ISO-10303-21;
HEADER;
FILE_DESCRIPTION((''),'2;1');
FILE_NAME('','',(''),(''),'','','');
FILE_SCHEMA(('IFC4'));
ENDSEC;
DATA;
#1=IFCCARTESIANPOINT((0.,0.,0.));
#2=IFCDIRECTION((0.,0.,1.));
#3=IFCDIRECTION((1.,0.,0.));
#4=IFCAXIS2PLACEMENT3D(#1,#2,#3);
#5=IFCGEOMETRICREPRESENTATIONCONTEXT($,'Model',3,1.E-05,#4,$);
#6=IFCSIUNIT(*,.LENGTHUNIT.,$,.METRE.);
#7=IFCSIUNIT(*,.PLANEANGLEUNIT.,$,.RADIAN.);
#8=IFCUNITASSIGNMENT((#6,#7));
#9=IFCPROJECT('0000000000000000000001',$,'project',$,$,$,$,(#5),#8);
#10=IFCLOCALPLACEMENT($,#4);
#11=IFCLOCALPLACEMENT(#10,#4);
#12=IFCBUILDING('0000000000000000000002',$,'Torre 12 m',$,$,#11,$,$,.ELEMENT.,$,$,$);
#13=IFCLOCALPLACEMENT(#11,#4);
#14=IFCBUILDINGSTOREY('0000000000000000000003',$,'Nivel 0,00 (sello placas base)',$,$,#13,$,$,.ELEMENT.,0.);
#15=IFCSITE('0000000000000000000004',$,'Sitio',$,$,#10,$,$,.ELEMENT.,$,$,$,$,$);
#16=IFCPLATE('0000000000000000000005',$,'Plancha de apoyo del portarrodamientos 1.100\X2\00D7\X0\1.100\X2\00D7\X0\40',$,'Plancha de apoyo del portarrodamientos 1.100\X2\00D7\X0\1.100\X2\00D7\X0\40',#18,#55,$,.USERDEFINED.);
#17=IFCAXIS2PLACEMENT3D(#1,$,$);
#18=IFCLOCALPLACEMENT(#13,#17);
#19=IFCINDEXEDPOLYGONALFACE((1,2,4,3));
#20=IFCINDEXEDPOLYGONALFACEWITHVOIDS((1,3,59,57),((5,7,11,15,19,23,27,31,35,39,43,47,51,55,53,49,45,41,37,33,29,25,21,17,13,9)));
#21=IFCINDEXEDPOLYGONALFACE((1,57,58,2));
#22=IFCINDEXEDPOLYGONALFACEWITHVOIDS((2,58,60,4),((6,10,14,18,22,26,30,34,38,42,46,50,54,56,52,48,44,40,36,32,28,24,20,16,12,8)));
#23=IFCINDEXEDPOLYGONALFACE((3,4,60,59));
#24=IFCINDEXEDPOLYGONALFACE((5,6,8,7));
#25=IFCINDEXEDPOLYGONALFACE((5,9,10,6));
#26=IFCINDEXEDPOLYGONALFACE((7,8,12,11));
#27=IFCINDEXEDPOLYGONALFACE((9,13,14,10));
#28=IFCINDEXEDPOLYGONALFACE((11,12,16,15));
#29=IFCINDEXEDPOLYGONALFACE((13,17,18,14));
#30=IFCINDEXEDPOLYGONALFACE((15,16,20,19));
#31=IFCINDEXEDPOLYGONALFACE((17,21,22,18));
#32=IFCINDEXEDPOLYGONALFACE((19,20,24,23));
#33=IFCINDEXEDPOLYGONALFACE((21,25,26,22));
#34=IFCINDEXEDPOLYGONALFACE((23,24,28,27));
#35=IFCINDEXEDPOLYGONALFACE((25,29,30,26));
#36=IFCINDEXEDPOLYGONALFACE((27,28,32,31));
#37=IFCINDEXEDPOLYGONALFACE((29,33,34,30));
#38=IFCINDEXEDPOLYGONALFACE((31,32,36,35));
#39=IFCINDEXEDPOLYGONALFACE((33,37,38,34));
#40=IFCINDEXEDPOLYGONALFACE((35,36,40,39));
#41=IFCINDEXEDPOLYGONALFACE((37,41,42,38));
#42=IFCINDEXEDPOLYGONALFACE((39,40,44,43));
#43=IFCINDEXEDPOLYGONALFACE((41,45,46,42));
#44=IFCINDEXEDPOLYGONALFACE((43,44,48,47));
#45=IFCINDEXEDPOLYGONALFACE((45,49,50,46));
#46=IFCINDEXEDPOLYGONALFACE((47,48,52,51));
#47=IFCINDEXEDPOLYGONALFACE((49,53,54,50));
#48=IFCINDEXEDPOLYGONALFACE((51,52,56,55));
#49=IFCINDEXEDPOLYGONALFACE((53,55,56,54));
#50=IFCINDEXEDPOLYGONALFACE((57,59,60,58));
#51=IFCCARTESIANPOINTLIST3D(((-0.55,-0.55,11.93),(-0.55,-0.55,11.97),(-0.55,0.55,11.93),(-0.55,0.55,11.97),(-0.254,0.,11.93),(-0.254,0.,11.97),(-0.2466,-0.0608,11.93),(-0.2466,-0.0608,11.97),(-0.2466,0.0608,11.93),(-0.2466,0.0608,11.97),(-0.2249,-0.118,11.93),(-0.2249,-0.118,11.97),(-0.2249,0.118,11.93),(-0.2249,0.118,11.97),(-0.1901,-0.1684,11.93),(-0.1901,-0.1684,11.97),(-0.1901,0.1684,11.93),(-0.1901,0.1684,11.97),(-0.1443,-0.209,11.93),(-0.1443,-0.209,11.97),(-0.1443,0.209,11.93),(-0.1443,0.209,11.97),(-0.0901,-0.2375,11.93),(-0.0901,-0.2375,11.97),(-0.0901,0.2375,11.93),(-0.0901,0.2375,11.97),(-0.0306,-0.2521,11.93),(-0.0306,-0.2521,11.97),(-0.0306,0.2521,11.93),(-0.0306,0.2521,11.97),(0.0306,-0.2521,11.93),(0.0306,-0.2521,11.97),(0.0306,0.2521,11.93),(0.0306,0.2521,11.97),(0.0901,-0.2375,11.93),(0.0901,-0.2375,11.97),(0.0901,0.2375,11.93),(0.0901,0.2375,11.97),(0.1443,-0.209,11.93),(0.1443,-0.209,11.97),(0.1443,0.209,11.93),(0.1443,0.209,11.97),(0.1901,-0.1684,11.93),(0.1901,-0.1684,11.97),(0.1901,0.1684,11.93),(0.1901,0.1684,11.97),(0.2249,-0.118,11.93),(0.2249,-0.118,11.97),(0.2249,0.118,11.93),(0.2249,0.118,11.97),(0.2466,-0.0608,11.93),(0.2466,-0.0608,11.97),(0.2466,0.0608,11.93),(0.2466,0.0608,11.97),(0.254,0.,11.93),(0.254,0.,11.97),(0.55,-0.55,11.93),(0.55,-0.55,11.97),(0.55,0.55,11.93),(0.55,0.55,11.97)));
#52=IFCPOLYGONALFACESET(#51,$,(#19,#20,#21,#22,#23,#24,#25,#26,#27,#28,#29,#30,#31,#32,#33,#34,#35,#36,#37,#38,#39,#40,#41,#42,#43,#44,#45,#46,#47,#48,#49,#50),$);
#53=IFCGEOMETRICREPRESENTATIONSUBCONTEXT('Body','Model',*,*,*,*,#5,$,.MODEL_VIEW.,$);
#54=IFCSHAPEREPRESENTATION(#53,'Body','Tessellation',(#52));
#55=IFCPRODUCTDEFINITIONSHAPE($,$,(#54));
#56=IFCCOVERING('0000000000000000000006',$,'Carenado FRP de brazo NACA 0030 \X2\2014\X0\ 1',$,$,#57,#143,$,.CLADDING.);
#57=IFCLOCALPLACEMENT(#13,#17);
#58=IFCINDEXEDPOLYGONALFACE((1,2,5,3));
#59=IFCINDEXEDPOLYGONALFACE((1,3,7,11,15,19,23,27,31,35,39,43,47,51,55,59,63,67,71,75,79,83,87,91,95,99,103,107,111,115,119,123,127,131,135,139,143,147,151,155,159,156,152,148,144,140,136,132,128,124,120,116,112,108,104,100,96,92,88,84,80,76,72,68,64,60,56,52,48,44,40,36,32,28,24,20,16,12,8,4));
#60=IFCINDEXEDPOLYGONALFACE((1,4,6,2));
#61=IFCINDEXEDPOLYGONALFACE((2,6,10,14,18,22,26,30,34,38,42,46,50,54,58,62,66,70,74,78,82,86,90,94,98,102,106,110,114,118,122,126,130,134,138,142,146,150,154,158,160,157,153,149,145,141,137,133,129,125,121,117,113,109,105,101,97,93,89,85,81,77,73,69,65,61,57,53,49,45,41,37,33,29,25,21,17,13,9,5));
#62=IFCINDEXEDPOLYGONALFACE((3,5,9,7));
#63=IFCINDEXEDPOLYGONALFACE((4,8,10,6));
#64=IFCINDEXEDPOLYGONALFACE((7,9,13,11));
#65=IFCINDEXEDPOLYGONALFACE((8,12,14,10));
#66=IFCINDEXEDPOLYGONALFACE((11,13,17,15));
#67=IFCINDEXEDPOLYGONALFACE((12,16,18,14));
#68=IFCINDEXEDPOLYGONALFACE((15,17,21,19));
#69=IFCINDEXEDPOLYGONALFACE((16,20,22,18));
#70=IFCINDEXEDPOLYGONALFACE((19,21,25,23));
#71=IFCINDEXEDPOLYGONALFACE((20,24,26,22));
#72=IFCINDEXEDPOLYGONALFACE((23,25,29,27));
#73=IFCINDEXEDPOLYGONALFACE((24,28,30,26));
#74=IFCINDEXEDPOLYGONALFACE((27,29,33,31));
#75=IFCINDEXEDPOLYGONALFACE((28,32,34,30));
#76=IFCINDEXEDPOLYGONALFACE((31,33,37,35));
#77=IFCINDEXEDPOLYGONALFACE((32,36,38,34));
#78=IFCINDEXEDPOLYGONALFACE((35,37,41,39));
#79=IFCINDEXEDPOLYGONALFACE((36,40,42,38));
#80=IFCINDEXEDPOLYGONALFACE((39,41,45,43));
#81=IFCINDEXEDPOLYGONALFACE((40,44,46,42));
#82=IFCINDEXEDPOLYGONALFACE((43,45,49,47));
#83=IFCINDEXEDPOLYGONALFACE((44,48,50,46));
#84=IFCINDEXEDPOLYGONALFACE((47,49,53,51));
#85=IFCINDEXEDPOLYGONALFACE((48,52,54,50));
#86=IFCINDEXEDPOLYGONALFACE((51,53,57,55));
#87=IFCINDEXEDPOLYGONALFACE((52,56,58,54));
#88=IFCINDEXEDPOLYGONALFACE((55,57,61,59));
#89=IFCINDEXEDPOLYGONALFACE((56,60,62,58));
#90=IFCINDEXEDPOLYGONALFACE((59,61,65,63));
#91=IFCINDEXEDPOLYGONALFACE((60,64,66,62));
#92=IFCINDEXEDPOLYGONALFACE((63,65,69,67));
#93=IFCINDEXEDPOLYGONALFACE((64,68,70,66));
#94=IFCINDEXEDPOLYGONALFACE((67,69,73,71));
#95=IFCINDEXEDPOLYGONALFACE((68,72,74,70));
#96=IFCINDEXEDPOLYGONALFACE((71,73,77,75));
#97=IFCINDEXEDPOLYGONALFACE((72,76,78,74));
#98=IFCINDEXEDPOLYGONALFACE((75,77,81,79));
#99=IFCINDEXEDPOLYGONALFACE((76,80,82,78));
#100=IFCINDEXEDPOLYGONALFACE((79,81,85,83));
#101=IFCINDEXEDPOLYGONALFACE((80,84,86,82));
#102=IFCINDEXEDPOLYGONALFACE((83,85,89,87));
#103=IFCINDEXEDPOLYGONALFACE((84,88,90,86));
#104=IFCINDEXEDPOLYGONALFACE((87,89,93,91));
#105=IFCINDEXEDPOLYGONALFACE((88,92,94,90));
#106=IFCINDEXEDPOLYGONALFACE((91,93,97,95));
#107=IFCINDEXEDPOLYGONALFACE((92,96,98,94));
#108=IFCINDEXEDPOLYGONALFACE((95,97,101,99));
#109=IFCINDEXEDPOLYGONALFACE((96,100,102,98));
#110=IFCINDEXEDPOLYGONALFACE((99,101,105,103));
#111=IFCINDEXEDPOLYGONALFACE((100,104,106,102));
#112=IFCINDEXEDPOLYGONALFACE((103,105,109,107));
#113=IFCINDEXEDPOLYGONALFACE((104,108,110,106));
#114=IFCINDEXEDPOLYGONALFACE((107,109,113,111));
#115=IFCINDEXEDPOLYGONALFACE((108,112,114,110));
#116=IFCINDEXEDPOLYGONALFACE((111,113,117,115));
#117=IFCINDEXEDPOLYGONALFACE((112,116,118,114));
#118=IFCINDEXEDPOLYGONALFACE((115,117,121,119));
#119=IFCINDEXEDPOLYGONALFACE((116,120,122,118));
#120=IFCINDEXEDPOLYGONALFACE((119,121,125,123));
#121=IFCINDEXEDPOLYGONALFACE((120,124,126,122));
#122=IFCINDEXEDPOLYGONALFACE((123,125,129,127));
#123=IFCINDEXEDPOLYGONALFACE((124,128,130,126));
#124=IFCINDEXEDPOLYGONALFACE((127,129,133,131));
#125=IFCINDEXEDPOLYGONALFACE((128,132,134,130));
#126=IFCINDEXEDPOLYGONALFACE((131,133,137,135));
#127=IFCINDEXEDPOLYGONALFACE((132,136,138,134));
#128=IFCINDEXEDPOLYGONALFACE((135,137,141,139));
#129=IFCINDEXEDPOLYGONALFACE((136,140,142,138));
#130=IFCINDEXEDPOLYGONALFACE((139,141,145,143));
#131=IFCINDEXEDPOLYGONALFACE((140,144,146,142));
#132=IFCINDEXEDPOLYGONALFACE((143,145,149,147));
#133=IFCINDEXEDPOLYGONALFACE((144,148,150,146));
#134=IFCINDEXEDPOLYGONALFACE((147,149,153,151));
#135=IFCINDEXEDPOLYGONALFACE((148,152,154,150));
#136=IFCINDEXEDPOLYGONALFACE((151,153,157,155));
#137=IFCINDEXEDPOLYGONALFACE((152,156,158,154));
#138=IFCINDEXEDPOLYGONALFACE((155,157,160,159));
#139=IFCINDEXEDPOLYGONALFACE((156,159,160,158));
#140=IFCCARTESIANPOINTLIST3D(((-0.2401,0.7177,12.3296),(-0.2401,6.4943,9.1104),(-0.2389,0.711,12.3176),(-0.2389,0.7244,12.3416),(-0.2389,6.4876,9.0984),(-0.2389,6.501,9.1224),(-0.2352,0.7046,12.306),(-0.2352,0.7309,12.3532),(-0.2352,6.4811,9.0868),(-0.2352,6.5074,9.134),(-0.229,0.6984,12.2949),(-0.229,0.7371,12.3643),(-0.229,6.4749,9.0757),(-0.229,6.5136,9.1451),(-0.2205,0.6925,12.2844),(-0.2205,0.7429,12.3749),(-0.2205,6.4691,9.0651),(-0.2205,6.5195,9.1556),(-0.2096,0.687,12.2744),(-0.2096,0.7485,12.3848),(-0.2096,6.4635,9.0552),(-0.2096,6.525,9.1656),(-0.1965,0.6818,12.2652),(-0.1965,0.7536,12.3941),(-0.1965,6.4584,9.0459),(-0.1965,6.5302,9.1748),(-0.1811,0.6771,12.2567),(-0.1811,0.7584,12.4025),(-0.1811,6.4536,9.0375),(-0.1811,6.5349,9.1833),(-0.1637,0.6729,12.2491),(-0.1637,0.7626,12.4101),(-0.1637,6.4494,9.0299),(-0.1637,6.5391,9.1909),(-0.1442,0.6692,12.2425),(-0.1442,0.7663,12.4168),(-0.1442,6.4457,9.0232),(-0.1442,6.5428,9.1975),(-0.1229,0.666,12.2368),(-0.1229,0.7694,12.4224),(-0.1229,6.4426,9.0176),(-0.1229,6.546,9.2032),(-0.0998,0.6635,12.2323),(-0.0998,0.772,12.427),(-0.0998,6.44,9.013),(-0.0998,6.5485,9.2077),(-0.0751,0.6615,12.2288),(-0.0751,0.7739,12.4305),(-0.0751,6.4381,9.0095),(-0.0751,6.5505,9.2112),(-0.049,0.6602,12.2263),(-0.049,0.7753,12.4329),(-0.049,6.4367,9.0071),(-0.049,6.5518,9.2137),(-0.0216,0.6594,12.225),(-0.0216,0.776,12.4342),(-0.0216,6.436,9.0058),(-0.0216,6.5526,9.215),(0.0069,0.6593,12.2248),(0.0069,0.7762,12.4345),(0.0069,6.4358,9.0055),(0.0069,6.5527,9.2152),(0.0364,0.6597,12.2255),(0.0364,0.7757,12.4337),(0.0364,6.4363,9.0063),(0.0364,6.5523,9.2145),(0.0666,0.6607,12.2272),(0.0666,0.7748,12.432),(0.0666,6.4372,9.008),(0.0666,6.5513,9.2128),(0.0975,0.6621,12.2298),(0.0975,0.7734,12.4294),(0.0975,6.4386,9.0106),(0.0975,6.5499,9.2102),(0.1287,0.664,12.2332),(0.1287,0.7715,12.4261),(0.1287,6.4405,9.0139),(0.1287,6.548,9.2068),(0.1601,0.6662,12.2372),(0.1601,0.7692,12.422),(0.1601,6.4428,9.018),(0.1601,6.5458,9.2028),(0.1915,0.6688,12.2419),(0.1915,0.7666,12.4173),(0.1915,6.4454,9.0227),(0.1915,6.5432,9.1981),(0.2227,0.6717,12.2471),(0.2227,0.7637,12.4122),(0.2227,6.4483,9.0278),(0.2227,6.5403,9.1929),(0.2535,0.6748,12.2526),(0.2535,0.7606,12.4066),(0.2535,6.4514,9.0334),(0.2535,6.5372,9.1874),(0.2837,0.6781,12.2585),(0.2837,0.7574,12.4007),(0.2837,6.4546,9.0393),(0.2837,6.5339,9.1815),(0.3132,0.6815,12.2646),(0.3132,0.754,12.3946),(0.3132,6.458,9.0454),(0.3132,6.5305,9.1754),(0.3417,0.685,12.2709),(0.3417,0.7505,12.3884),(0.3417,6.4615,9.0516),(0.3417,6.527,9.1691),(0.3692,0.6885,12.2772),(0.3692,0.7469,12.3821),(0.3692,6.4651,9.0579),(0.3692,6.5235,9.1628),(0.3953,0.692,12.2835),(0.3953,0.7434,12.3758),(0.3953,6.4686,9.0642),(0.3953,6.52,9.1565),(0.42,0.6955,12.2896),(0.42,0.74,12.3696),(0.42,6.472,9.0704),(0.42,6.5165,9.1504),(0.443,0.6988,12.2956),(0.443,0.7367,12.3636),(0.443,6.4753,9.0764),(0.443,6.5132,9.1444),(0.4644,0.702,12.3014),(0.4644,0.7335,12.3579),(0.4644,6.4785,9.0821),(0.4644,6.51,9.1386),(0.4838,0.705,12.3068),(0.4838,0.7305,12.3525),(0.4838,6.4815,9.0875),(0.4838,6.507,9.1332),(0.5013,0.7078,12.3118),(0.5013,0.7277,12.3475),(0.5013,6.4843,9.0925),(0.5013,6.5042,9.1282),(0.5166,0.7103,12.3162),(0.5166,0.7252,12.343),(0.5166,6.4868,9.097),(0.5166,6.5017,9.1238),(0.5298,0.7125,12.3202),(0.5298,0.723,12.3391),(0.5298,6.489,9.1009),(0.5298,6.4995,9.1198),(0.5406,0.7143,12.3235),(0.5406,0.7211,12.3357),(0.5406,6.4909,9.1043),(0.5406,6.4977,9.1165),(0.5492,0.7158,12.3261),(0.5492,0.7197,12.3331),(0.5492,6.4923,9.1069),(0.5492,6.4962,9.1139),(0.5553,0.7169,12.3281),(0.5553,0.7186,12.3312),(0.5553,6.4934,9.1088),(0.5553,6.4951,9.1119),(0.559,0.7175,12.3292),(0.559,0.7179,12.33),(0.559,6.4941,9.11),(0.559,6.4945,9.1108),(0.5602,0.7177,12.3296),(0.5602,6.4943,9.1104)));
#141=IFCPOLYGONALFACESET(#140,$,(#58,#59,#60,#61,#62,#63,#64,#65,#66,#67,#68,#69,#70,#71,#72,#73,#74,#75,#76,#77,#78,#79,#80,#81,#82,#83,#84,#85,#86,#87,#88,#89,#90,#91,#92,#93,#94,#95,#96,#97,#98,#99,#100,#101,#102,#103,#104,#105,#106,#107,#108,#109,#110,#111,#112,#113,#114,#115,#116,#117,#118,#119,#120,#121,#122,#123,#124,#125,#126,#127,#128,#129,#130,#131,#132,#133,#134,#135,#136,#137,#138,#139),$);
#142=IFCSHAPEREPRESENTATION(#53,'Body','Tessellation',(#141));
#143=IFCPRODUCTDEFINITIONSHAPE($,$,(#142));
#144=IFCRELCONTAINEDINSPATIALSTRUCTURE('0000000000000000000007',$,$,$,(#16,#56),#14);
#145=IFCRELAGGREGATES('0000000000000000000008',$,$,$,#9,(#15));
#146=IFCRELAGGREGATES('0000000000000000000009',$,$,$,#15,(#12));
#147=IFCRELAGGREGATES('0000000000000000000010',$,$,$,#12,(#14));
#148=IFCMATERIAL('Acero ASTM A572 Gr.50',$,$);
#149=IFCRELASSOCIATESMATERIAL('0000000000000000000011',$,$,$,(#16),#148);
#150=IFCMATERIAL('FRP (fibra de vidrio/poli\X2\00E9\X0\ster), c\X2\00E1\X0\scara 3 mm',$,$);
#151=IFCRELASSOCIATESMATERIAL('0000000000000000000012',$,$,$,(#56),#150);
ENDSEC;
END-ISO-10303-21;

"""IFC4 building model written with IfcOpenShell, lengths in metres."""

from ifc_helpers import new_model, si_unit, frame, origin, origin_with_axes, origin_2d, place, context, subcontext, project, spatial, polyline, circle_curve, outline, extrude, material, element, save


model = new_model("IFC4")

# Units and contexts
model_context = context("Model", 3, precision=1e-05, world=origin_with_axes())
body_context = subcontext(model_context, "Body", "Model", "MODEL_VIEW")
ifc_project = project(units=[si_unit("LENGTHUNIT", "METRE"), si_unit("PLANEANGLEUNIT", "RADIAN")], contexts=[model_context])

# Site, building, storey
site_placement = place(None, origin_with_axes())
site = spatial("IfcSite", under=ifc_project, at=site_placement, Name="Sitio", CompositionType="ELEMENT")
building_placement = place(site_placement, origin_with_axes())
building = spatial("IfcBuilding", under=site, at=building_placement, Name="Torre 12 m", CompositionType="ELEMENT")
storey_placement = place(building_placement, origin_with_axes())
storey = spatial("IfcBuildingStorey", under=building, at=storey_placement, Name="Nivel 0,00 (sello placas base)", CompositionType="ELEMENT", Elevation=0.0)

# Shared definitions
ifc_material_1 = material(Name="Acero ASTM A572 Gr.50")

# Plate
plate_1_placement = place(storey_placement, frame((0.0, 0.0, 11.93), z_axis=(0.0, 0.0, 1.0), x_axis=(1.0, 0.0, 0.0)))
element("IfcPlate", 1, at=plate_1_placement, inside=storey, material=ifc_material_1, Name="Plancha de apoyo del portarrodamientos 1.100×1.100×40", ObjectType="Plancha de apoyo del portarrodamientos 1.100×1.100×40", PredefinedType="USERDEFINED", context=body_context, shape_type="SweptSolid", body=[
    extrude(outline(polyline([(-0.55, -0.55), (0.55, -0.55), (0.55, 0.55), (-0.55, 0.55), (-0.55, -0.55)]), holes=[circle_curve(origin_2d(), 0.254)]), origin(), (0.0, 0.0, 1.0), 0.04),
])

# Covering
ifc_material_2 = material(Name="FRP (fibra de vidrio/poliéster), cáscara 3 mm")
covering_1_placement = place(storey_placement, frame((0.0, 0.7177, 12.3296), z_axis=(0.0, 0.873511, -0.486804), x_axis=(-1.0, 0.0, 0.0)))
element("IfcCovering", 2, at=covering_1_placement, inside=storey, material=ifc_material_2, Name="Carenado FRP de brazo NACA 0030 — 1", PredefinedType="CLADDING", context=body_context, shape_type="SweptSolid", body=[
    extrude(outline(polyline([(0.2401, 0.0), (0.2389, 0.0138), (0.2352, 0.027), (0.229, 0.0397), (0.2205, 0.0518), (0.2096, 0.0632), (0.1965, 0.0738), (0.1811, 0.0834), (0.1637, 0.0921), (0.1442, 0.0997), (0.1229, 0.1062), (0.0998, 0.1115), (0.0751, 0.1155), (0.049, 0.1182), (0.0216, 0.1197), (-0.0069, 0.12), (-0.0364, 0.1192), (-0.0666, 0.1172), (-0.0975, 0.1143), (-0.1287, 0.1104), (-0.1601, 0.1058), (-0.1915, 0.1004), (-0.2227, 0.0945), (-0.2535, 0.0881), (-0.2837, 0.0814), (-0.3132, 0.0744), (-0.3417, 0.0672), (-0.3692, 0.06), (-0.3953, 0.0528), (-0.42, 0.0458), (-0.443, 0.0389), (-0.4644, 0.0323), (-0.4838, 0.0262), (-0.5013, 0.0205), (-0.5166, 0.0153), (-0.5298, 0.0108), (-0.5406, 0.007), (-0.5492, 0.004), (-0.5553, 0.0018), (-0.559, 0.0004), (-0.5602, 0.0), (-0.559, -0.0004), (-0.5553, -0.0018), (-0.5492, -0.004), (-0.5406, -0.007), (-0.5298, -0.0108), (-0.5166, -0.0153), (-0.5013, -0.0205), (-0.4838, -0.0262), (-0.4644, -0.0323), (-0.443, -0.0389), (-0.42, -0.0458), (-0.3953, -0.0528), (-0.3692, -0.06), (-0.3417, -0.0672), (-0.3132, -0.0744), (-0.2837, -0.0814), (-0.2535, -0.0881), (-0.2227, -0.0945), (-0.1915, -0.1004), (-0.1601, -0.1058), (-0.1287, -0.1104), (-0.0975, -0.1143), (-0.0666, -0.1172), (-0.0364, -0.1192), (-0.0069, -0.12), (0.0216, -0.1197), (0.049, -0.1182), (0.0751, -0.1155), (0.0998, -0.1115), (0.1229, -0.1062), (0.1442, -0.0997), (0.1637, -0.0921), (0.1811, -0.0834), (0.1965, -0.0738), (0.2096, -0.0632), (0.2205, -0.0518), (0.229, -0.0397), (0.2352, -0.027), (0.2389, -0.0138), (0.2401, 0.0)])), origin(), (0.0, 0.0, 1.0), 6.613),
])

save(model, "model.ifc")
